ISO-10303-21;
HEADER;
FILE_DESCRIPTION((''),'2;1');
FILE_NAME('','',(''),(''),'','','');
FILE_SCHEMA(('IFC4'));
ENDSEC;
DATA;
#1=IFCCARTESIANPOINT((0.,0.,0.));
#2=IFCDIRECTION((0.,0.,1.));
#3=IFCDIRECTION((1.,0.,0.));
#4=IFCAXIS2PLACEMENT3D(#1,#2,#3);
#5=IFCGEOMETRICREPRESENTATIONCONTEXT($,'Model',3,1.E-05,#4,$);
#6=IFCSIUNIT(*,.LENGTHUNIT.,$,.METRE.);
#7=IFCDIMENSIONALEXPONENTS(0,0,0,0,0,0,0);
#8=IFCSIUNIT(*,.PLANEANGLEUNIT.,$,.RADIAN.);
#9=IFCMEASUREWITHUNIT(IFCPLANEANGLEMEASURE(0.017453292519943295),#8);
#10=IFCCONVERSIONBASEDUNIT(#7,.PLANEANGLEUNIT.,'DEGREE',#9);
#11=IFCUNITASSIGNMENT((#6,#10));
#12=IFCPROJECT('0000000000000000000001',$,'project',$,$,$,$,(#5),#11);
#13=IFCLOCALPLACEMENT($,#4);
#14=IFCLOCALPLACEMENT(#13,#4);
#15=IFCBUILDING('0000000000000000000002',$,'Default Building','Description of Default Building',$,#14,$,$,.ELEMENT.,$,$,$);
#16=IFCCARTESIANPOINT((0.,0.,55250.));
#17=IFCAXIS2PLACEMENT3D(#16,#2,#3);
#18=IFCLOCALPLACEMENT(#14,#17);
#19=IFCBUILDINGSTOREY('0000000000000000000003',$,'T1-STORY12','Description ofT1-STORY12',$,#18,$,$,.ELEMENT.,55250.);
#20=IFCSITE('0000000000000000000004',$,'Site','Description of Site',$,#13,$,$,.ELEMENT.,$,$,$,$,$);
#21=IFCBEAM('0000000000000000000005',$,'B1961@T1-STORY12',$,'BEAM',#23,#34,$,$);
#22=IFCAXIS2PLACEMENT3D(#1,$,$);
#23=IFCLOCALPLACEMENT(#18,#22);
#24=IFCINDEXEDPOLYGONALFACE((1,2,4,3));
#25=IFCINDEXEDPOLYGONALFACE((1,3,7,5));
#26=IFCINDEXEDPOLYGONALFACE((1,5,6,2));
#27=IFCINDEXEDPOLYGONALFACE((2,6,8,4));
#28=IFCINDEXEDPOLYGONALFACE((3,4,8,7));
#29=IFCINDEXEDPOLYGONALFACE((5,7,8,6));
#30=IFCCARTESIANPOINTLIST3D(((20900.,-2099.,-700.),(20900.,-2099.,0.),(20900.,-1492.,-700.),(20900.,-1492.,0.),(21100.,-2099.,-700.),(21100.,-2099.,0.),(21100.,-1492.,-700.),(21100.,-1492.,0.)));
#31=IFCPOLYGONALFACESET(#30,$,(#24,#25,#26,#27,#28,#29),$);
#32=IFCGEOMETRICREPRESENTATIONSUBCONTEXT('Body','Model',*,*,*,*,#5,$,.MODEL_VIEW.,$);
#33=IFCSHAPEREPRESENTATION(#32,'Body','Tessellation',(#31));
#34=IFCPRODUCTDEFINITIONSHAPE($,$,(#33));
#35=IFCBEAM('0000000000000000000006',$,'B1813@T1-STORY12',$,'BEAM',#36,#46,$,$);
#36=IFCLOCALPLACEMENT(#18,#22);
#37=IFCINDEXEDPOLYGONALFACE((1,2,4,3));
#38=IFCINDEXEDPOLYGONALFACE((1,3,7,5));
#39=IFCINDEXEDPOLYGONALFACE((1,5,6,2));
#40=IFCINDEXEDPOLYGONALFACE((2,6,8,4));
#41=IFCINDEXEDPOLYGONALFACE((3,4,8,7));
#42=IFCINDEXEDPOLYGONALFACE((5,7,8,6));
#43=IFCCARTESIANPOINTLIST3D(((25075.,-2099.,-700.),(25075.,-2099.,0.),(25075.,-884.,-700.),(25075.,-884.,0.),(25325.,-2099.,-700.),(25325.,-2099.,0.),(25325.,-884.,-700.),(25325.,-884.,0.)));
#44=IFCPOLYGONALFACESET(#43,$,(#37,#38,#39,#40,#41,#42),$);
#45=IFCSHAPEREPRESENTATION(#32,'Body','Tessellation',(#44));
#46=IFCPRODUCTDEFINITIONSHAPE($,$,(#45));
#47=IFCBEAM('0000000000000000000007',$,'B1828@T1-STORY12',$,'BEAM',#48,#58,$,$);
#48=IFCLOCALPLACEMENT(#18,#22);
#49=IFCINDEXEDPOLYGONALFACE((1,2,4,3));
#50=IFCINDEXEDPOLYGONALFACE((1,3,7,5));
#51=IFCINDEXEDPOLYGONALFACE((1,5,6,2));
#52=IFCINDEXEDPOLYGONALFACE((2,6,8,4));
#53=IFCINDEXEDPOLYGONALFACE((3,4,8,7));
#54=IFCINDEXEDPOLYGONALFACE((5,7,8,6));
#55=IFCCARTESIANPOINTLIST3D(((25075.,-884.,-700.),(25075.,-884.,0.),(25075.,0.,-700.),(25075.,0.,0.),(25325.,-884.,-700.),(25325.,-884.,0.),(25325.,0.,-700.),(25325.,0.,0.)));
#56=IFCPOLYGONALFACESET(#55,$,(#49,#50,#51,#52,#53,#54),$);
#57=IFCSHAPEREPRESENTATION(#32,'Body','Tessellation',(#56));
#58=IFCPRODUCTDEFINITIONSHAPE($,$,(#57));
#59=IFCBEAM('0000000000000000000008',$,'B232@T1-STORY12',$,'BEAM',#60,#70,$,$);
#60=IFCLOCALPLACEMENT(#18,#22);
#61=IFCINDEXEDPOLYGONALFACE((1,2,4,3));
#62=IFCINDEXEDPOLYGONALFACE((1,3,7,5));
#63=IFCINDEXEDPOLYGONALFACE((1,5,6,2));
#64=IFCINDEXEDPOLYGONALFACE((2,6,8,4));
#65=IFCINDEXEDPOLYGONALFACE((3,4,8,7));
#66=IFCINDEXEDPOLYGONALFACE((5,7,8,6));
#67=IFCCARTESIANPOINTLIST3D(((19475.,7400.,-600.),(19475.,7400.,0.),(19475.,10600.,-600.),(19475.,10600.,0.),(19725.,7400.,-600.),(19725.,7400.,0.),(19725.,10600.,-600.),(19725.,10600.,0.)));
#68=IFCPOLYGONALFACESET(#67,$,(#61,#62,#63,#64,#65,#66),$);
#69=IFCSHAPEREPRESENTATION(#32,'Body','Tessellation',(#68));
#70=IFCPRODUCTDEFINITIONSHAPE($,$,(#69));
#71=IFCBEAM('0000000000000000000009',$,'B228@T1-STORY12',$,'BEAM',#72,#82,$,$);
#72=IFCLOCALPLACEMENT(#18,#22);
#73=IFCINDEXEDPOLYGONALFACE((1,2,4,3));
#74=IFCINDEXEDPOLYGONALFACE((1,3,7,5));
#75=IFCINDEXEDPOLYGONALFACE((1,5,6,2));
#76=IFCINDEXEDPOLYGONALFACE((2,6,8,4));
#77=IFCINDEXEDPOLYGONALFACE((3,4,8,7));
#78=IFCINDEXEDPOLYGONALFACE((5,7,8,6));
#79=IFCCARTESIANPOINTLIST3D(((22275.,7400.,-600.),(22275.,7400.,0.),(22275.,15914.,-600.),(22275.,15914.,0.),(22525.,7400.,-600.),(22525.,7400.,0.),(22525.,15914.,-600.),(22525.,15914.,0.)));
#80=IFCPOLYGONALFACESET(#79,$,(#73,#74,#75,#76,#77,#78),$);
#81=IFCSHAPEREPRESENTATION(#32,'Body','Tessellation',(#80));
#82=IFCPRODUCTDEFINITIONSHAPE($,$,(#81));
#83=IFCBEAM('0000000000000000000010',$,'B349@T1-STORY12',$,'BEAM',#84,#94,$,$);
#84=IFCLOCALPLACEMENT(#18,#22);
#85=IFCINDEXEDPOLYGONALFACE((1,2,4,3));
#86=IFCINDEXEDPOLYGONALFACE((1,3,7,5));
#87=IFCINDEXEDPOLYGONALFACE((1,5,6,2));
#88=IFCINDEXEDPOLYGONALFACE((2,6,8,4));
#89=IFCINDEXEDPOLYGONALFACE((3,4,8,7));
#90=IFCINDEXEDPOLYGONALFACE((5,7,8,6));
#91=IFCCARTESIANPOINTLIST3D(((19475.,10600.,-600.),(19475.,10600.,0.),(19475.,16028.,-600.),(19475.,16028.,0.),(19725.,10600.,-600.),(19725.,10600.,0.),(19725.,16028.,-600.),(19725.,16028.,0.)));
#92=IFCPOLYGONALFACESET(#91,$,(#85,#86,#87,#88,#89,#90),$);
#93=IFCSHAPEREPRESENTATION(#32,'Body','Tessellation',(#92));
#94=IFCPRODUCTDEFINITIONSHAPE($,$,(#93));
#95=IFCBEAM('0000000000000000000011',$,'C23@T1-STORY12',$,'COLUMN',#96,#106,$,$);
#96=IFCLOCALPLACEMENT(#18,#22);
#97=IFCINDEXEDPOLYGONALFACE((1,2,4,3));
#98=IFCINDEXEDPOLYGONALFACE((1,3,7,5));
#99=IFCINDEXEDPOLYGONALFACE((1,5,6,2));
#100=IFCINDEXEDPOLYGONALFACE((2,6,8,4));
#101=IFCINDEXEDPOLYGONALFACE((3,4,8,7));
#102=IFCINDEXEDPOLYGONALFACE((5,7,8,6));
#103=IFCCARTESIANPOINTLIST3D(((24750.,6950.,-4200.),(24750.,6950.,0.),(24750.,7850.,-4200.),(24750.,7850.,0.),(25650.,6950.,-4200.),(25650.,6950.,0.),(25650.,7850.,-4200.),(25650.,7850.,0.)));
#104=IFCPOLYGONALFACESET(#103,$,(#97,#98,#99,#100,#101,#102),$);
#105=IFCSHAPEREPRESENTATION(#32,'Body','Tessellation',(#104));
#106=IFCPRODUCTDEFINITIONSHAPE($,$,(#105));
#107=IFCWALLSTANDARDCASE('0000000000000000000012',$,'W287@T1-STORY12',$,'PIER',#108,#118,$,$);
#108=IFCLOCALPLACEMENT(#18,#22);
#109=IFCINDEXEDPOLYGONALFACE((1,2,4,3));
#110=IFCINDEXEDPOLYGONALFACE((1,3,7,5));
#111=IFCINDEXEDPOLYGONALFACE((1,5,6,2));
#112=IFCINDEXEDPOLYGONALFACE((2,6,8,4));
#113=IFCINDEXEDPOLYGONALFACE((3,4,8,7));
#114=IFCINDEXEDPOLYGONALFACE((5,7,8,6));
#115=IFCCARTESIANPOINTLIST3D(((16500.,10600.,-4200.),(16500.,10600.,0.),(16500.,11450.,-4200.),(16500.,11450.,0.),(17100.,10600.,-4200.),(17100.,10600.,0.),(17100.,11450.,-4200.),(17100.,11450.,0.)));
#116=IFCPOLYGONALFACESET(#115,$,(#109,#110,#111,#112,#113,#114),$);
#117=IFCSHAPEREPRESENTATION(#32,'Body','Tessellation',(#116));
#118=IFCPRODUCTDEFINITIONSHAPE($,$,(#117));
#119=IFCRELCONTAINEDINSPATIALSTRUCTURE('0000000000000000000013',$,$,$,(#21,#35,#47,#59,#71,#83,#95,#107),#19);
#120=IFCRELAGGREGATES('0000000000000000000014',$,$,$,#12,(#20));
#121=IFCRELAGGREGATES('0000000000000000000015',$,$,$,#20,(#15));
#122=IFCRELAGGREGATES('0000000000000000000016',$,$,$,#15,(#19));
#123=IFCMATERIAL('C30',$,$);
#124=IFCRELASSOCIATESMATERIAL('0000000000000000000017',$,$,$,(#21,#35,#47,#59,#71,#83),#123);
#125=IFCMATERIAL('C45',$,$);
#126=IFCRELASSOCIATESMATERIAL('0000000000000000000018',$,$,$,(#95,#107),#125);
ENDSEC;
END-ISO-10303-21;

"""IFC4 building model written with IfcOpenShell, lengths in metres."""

from ifc_helpers import new_model, entity, si_unit, converted_unit, frame, origin_with_axes, place, context, subcontext, project, spatial, indexed_curve, rectangle, outline, extrude, material, element, save


model = new_model("IFC4")

# Units and contexts
model_context = context("Model", 3, precision=1e-05, world=origin_with_axes())
body_context = subcontext(model_context, "Body", "Model", "MODEL_VIEW")
ifc_project = project(units=[si_unit("LENGTHUNIT", "METRE"), converted_unit("PLANEANGLEUNIT", "DEGREE", entity("IfcPlaneAngleMeasure", 0.017453292519943295), si_unit("PLANEANGLEUNIT", "RADIAN"), dimensions=[0, 0, 0, 0, 0, 0, 0])], contexts=[model_context])

# Site, building, storey
site_placement = place(None, origin_with_axes())
site = spatial("IfcSite", under=ifc_project, at=site_placement, Name="Site", Description="Description of Site", CompositionType="ELEMENT")
building_placement = place(site_placement, origin_with_axes())
building = spatial("IfcBuilding", under=site, at=building_placement, Name="Default Building", Description="Description of Default Building", CompositionType="ELEMENT")
storey_placement = place(building_placement, frame((0.0, 0.0, 55250.0), z_axis=(0.0, 0.0, 1.0), x_axis=(1.0, 0.0, 0.0)))
storey = spatial("IfcBuildingStorey", under=building, at=storey_placement, Name="T1-STORY12", Description="Description ofT1-STORY12", CompositionType="ELEMENT", Elevation=55250.0)

# Beams
ifc_material_1 = material(Name="C30")
beam_1_placement = place(storey_placement, frame((21000.0, -2099.0, -350.0), z_axis=(0.0, 1.0, 0.0), x_axis=(-1.0, 0.0, 0.0)))
element("IfcBeam", 1, at=beam_1_placement, inside=storey, material=ifc_material_1, Name="B1961@T1-STORY12", ObjectType="BEAM", context=body_context, shape_type="SweptSolid", body=[
    extrude(rectangle(XDim=200.0, YDim=700.0), origin_with_axes(), (0.0, 0.0, 1.0), 607.0),
])
beam_2_placement = place(storey_placement, frame((25200.0, -2099.0, -350.0), z_axis=(0.0, 1.0, 0.0), x_axis=(-1.0, 0.0, 0.0)))
element("IfcBeam", 2, at=beam_2_placement, inside=storey, material=ifc_material_1, Name="B1813@T1-STORY12", ObjectType="BEAM", context=body_context, shape_type="SweptSolid", body=[
    extrude(rectangle(XDim=250.0, YDim=700.0), origin_with_axes(), (0.0, 0.0, 1.0), 1215.0),
])
beam_3_placement = place(storey_placement, frame((25200.0, -884.0, -350.0), z_axis=(0.0, 1.0, 0.0), x_axis=(-1.0, 0.0, 0.0)))
element("IfcBeam", 3, at=beam_3_placement, inside=storey, material=ifc_material_1, Name="B1828@T1-STORY12", ObjectType="BEAM", context=body_context, shape_type="SweptSolid", body=[
    extrude(rectangle(XDim=250.0, YDim=700.0), origin_with_axes(), (0.0, 0.0, 1.0), 884.0),
])
beam_4_placement = place(storey_placement, frame((19600.0, 7400.0, -300.0), z_axis=(0.0, 1.0, 0.0), x_axis=(-1.0, 0.0, 0.0)))
element("IfcBeam", 4, at=beam_4_placement, inside=storey, material=ifc_material_1, Name="B232@T1-STORY12", ObjectType="BEAM", context=body_context, shape_type="SweptSolid", body=[
    extrude(rectangle(XDim=250.0, YDim=600.0), origin_with_axes(), (0.0, 0.0, 1.0), 3200.0),
])
beam_5_placement = place(storey_placement, frame((22400.0, 7400.0, -300.0), z_axis=(0.0, 1.0, 0.0), x_axis=(-1.0, 0.0, 0.0)))
element("IfcBeam", 5, at=beam_5_placement, inside=storey, material=ifc_material_1, Name="B228@T1-STORY12", ObjectType="BEAM", context=body_context, shape_type="SweptSolid", body=[
    extrude(rectangle(XDim=250.0, YDim=600.0), origin_with_axes(), (0.0, 0.0, 1.0), 8514.0),
])
beam_6_placement = place(storey_placement, frame((19600.0, 10600.0, -300.0), z_axis=(0.0, 1.0, 0.0), x_axis=(-1.0, 0.0, 0.0)))
element("IfcBeam", 6, at=beam_6_placement, inside=storey, material=ifc_material_1, Name="B349@T1-STORY12", ObjectType="BEAM", context=body_context, shape_type="SweptSolid", body=[
    extrude(rectangle(XDim=250.0, YDim=600.0), origin_with_axes(), (0.0, 0.0, 1.0), 5428.0),
])
ifc_material_2 = material(Name="C45")
beam_7_placement = place(storey_placement, frame((25200.0, 7400.0, -4200.0), z_axis=(0.0, 0.0, 1.0), x_axis=(-1.0, 0.0, 0.0)))
element("IfcBeam", 7, at=beam_7_placement, inside=storey, material=ifc_material_2, Name="C23@T1-STORY12", ObjectType="COLUMN", context=body_context, shape_type="SweptSolid", body=[
    extrude(rectangle(XDim=900.0, YDim=900.0), origin_with_axes(), (0.0, 0.0, 1.0), 4200.0),
])

# Wall
wall_placement = place(storey_placement, frame((16800.0, 10600.0, -4200.0), z_axis=(0.0, 0.0, 1.0), x_axis=(0.0, 1.0, 0.0)))
element("IfcWallStandardCase", 8, at=wall_placement, inside=storey, material=ifc_material_2, Name="W287@T1-STORY12", ObjectType="PIER", context=body_context, shape_type="SweptSolid", body=[
    extrude(outline(indexed_curve([(0.0, -300.0), (0.0, 300.0), (850.0, 300.0), (850.0, -300.0), (0.0, -300.0)], self_intersect=False)), origin_with_axes(), (0.0, 0.0, 1.0), 4200.0),
])

save(model, "model.ifc")
